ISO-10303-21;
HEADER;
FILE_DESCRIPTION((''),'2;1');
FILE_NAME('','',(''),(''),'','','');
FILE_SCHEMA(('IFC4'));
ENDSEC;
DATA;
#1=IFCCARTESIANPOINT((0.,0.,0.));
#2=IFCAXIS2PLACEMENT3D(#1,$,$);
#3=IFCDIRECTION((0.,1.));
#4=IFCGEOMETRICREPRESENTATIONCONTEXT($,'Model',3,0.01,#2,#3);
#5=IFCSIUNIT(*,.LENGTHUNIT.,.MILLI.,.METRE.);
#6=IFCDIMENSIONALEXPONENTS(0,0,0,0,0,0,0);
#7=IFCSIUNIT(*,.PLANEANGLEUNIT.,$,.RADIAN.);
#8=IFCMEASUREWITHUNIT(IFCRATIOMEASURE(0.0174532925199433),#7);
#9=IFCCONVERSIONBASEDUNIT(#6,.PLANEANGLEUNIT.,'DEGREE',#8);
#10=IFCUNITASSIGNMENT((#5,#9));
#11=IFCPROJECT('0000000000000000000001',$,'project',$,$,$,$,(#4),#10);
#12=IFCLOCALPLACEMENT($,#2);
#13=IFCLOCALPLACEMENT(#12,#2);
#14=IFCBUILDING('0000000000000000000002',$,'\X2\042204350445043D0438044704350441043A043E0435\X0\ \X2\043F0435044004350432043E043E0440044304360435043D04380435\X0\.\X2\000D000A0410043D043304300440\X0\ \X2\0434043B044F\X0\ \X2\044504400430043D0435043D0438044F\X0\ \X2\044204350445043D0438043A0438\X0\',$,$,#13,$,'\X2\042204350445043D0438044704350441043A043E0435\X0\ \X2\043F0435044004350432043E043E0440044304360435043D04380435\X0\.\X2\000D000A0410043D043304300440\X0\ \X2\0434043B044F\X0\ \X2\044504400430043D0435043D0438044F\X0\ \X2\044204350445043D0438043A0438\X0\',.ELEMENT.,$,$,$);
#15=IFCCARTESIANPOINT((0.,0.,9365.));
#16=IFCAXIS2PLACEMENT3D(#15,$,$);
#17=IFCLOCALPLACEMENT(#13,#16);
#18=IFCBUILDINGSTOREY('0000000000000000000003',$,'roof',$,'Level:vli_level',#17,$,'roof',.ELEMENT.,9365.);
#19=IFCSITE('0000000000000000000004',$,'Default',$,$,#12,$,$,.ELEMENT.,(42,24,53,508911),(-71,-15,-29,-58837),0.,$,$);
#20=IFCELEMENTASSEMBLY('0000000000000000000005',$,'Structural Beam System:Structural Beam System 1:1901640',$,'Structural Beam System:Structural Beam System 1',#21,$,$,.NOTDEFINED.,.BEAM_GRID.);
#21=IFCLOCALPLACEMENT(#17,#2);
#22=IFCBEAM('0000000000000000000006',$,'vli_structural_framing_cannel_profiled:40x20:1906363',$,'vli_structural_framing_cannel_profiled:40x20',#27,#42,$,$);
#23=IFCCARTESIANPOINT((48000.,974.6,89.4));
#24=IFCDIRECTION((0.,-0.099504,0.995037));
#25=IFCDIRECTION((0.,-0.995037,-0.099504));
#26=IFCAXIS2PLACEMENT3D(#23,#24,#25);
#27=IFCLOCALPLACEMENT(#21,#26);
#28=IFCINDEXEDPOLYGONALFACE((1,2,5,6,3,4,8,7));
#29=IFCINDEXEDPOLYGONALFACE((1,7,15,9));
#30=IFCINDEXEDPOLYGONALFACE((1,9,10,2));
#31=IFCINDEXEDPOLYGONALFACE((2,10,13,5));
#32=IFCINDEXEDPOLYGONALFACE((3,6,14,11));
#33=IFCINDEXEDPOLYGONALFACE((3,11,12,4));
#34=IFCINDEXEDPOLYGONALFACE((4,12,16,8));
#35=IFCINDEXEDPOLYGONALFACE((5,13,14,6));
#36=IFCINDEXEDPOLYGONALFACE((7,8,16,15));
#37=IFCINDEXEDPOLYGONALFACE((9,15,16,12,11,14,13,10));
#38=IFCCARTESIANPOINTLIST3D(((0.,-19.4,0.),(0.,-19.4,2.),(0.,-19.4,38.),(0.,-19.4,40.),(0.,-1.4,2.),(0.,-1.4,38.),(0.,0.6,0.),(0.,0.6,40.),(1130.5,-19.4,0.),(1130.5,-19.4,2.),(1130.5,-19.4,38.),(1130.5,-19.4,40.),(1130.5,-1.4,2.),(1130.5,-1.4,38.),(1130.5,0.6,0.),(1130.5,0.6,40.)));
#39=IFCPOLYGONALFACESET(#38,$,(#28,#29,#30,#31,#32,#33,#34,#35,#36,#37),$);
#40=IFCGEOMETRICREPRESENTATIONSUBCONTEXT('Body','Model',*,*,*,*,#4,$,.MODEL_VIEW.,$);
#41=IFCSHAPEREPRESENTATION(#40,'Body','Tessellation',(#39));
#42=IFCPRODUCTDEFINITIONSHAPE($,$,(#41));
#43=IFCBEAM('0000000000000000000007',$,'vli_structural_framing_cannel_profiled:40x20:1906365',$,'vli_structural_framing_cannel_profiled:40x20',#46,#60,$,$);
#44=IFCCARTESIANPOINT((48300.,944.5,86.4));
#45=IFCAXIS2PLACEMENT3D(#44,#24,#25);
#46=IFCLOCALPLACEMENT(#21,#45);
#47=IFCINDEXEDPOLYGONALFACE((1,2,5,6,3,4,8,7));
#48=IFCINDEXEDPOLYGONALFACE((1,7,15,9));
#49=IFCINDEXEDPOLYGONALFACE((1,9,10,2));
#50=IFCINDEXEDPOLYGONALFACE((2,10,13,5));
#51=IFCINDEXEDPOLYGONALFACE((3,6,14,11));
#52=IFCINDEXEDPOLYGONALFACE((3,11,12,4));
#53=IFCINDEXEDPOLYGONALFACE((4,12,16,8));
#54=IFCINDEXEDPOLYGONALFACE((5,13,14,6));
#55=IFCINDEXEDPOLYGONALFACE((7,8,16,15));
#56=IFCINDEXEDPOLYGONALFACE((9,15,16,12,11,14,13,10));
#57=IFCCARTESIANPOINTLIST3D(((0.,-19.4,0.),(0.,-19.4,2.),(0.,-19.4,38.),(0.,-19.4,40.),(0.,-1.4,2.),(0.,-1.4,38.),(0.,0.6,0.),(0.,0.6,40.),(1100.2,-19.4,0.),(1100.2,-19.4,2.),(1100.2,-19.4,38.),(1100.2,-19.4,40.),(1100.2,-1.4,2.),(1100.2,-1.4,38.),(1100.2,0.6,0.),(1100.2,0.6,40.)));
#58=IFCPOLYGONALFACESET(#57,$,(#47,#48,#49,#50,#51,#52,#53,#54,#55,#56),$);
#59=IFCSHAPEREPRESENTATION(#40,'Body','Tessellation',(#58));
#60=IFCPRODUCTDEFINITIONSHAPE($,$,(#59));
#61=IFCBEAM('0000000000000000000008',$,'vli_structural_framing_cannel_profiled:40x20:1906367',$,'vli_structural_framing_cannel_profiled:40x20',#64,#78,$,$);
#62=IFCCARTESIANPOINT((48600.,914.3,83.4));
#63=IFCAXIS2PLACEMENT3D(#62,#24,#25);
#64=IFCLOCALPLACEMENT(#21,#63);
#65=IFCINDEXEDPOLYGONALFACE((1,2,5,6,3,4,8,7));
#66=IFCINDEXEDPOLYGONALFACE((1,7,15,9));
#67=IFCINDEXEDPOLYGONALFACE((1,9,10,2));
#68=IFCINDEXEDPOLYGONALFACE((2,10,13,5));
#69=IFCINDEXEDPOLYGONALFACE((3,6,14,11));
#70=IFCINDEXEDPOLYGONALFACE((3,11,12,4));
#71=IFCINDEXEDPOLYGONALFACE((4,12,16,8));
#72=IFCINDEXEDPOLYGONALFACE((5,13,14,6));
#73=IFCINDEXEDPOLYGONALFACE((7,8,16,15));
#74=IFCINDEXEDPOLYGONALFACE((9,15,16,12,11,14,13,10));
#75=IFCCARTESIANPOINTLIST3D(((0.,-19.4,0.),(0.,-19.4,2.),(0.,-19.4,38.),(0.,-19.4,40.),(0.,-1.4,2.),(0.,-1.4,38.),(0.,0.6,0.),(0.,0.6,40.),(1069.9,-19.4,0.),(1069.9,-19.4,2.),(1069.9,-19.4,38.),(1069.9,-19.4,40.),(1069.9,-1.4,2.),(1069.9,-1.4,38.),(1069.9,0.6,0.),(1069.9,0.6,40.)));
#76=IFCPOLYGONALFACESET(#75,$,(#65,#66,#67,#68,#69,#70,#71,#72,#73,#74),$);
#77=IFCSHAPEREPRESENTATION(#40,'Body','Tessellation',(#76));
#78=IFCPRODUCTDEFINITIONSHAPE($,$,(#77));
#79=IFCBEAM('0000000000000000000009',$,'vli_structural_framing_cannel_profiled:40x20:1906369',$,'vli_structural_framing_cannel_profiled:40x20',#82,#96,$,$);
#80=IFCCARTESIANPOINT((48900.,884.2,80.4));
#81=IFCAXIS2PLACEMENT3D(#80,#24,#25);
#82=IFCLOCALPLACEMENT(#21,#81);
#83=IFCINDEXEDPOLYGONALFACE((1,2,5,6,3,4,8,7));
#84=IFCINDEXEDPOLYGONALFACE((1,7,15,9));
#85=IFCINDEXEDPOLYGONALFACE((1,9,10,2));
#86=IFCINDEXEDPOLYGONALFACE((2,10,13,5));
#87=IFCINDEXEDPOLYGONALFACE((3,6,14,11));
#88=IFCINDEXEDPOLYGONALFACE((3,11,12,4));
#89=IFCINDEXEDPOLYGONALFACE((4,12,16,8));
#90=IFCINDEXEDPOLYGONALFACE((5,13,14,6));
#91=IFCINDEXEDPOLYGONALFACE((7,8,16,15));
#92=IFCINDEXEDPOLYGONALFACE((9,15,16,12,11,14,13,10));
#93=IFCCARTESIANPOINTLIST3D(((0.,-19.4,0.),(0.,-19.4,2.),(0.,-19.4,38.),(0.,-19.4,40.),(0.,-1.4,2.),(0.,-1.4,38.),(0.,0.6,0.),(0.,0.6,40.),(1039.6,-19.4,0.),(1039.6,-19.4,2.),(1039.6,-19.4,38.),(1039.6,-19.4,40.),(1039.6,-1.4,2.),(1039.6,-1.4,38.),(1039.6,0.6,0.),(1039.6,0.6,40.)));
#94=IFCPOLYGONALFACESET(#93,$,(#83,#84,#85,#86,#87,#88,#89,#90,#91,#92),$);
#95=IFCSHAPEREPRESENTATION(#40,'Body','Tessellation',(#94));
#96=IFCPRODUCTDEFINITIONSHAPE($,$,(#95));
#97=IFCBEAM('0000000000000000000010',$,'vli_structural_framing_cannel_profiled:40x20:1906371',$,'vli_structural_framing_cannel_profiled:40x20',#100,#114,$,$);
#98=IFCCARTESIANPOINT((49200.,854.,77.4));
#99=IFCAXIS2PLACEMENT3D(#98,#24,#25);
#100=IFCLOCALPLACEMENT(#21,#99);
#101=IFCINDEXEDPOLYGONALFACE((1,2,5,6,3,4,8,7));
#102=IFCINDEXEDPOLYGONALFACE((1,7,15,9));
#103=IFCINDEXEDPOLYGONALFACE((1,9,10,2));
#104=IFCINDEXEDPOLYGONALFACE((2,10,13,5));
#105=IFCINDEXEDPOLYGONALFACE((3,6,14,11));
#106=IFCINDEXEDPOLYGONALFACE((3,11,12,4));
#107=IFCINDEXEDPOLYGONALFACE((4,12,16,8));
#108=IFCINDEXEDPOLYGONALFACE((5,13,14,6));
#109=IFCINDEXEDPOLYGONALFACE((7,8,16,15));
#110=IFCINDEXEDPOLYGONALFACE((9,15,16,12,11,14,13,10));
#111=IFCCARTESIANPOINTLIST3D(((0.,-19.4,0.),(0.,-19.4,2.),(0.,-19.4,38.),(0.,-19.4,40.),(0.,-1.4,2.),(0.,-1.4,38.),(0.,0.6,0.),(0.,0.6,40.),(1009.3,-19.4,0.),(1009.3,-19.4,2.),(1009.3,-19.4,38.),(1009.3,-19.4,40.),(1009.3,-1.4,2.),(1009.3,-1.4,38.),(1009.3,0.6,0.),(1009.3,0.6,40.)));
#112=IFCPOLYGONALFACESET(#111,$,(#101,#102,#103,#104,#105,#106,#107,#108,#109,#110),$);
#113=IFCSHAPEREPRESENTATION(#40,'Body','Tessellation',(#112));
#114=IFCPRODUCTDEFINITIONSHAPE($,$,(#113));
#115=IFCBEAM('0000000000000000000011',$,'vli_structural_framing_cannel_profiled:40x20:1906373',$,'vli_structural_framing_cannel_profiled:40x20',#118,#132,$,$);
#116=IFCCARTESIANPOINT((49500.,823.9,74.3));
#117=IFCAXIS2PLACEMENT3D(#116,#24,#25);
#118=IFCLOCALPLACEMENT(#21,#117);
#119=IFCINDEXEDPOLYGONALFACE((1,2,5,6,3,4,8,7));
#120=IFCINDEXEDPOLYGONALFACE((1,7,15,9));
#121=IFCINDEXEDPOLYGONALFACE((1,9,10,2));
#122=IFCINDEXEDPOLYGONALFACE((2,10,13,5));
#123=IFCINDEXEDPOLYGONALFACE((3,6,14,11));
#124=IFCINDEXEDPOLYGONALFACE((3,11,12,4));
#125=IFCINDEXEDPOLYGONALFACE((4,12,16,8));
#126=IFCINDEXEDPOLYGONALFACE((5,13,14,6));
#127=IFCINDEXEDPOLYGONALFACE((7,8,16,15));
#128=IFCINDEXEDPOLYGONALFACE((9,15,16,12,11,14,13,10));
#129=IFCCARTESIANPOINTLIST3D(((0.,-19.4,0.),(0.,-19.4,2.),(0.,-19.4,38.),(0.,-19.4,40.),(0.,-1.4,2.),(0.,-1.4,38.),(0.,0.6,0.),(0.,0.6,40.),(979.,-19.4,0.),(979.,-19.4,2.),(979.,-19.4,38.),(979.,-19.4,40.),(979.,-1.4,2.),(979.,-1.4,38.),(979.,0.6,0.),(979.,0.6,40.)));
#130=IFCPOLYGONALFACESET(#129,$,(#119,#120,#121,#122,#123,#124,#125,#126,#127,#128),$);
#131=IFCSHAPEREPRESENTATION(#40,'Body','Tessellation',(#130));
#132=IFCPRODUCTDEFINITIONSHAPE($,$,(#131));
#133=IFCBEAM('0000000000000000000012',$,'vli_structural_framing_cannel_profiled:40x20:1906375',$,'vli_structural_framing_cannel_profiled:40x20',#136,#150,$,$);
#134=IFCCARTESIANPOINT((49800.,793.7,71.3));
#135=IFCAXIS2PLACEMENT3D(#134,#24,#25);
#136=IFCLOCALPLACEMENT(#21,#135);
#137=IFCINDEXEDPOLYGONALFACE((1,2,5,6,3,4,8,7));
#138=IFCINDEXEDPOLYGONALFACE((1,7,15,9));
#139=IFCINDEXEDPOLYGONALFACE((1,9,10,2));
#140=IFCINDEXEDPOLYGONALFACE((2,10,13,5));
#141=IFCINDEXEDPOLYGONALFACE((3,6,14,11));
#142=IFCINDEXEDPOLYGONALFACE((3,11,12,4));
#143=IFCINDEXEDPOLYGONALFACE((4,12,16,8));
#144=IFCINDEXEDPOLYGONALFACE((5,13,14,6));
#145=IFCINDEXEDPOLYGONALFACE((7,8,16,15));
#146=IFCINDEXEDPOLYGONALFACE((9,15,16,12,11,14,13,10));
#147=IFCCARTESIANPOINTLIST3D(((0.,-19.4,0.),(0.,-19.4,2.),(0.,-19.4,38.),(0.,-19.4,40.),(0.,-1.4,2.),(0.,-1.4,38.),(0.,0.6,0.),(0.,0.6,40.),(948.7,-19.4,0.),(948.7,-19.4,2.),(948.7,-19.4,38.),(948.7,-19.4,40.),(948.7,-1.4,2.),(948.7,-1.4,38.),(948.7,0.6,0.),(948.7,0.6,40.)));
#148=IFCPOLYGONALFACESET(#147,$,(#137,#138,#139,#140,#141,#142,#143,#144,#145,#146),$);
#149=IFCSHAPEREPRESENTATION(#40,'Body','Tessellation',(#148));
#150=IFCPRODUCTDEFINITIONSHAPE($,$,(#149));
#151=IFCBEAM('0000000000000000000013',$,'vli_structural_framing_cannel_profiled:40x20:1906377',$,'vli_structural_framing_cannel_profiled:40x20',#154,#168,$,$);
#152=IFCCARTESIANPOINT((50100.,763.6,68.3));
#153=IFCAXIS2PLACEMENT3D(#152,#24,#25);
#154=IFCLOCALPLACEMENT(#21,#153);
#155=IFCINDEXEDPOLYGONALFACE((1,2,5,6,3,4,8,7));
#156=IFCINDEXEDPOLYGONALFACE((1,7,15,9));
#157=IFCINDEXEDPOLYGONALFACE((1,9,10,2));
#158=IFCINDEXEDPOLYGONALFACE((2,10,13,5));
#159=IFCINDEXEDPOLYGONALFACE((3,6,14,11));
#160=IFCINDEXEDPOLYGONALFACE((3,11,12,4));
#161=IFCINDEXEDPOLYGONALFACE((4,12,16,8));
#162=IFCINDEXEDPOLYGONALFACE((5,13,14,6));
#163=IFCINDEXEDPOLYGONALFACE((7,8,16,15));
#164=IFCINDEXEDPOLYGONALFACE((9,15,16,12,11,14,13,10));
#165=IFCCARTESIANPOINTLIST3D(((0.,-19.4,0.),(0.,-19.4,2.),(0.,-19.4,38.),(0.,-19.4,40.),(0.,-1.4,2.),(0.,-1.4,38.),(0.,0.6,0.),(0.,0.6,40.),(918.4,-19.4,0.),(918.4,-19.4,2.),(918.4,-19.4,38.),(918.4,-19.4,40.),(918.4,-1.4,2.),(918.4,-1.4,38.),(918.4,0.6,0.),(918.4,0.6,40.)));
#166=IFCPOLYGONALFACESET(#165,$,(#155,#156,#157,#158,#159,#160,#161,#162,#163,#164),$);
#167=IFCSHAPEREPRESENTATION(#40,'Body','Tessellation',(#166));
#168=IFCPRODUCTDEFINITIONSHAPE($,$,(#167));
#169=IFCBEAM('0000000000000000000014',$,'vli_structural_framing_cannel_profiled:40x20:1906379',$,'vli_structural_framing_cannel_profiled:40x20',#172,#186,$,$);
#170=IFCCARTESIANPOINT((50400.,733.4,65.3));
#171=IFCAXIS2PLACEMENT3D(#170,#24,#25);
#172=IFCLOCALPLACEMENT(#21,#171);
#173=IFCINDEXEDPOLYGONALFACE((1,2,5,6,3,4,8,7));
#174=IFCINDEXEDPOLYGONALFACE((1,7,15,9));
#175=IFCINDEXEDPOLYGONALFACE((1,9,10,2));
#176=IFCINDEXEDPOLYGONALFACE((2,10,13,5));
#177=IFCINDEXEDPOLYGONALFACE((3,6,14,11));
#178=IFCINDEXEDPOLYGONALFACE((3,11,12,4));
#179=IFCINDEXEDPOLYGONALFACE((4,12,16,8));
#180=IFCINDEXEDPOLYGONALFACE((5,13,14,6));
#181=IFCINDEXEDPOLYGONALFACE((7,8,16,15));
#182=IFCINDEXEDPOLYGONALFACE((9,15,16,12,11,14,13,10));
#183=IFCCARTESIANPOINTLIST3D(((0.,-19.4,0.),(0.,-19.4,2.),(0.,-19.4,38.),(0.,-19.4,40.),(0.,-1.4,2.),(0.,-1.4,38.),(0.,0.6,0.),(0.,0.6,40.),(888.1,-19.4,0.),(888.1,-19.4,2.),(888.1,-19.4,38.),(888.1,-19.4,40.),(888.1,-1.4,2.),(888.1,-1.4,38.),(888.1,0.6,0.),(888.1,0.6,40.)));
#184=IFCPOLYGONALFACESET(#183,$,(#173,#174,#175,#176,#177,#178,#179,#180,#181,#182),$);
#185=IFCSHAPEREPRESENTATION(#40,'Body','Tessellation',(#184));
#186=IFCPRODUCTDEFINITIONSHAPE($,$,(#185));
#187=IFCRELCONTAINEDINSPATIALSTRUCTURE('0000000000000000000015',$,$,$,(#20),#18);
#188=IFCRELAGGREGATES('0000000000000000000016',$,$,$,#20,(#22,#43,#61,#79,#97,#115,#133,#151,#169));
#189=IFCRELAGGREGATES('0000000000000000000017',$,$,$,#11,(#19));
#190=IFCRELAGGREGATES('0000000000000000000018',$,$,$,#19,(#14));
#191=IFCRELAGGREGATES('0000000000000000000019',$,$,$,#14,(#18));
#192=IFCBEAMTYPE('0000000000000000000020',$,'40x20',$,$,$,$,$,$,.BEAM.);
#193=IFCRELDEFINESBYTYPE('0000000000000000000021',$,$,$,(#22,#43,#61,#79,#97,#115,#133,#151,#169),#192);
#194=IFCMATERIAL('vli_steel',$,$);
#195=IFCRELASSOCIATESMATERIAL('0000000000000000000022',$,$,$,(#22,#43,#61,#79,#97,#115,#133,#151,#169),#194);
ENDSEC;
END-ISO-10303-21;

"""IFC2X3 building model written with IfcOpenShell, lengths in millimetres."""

from ifc_helpers import new_model, entity, si_unit, converted_unit, direction, frame, origin, place, context, subcontext, project, spatial, polyline, outline, extrude, material, type_object, element, aggregate, save


model = new_model("IFC2X3")

# Units and contexts
model_context = context("Model", 3, precision=0.01, world=origin(), true_north=direction((0.0, 1.0)))
body_context = subcontext(model_context, "Body", "Model", "MODEL_VIEW")
ifc_project = project(units=[si_unit("LENGTHUNIT", "METRE", prefix="MILLI"), converted_unit("PLANEANGLEUNIT", "DEGREE", entity("IfcRatioMeasure", 0.0174532925199433), si_unit("PLANEANGLEUNIT", "RADIAN"), dimensions=[0, 0, 0, 0, 0, 0, 0])], contexts=[model_context])

# Site, building, storey
site_placement = place(None, origin())
site = spatial("IfcSite", under=ifc_project, at=site_placement, Name="Default", CompositionType="ELEMENT", RefLatitude=(42, 24, 53, 508911), RefLongitude=(-71, -15, -29, -58837), RefElevation=0.0)
building_placement = place(site_placement, origin())
building = spatial("IfcBuilding", under=site, at=building_placement, Name="Техническое перевооружение.\r\nАнгар для хранения техники", LongName="Техническое перевооружение.\r\nАнгар для хранения техники", CompositionType="ELEMENT")
storey_placement = place(building_placement, frame((0.0, 0.0, 9365.0)))
storey = spatial("IfcBuildingStorey", under=building, at=storey_placement, Name="roof", ObjectType="Level:vli_level", LongName="roof", CompositionType="ELEMENT", Elevation=9365.0)

# Element assembly, beams
assembly_1_placement = place(storey_placement, origin())
assembly_1 = element("IfcElementAssembly", 1, at=assembly_1_placement, inside=storey, Name="Structural Beam System:Structural Beam System 1:1901640", ObjectType="Structural Beam System:Structural Beam System 1", AssemblyPlace="NOTDEFINED", PredefinedType="BEAM_GRID")
ifc_material = material(Name="vli_steel")
beam_type = type_object("IfcBeamType", Name="40x20", PredefinedType="BEAM")
beam_1_placement = place(assembly_1_placement, frame((48000.0, 974.6, 89.4), z_axis=(0.0, -0.099504, 0.995037), x_axis=(0.0, -0.995037, -0.099504)))
beam_1 = element("IfcBeam", 2, at=beam_1_placement, type_object=beam_type, material=ifc_material, Name="vli_structural_framing_cannel_profiled:40x20:1906363", ObjectType="vli_structural_framing_cannel_profiled:40x20", context=body_context, shape_type="SweptSolid", body=[
    extrude(outline(polyline([(-20.0, -9.5), (-18.0, -9.5), (-18.0, 8.5), (18.0, 8.5), (18.0, -9.5), (20.0, -9.5), (20.0, 10.5), (-20.0, 10.5), (-20.0, -9.5)])), frame((0.0, -9.9, 20.0), z_axis=(1.0, 0.0, 0.0), x_axis=(0.0, 0.0, -1.0)), (0.0, 0.0, 1.0), 1130.5),
])
beam_2_placement = place(assembly_1_placement, frame((48300.0, 944.5, 86.4), z_axis=(0.0, -0.099504, 0.995037), x_axis=(0.0, -0.995037, -0.099504)))
beam_2 = element("IfcBeam", 3, at=beam_2_placement, type_object=beam_type, material=ifc_material, Name="vli_structural_framing_cannel_profiled:40x20:1906365", ObjectType="vli_structural_framing_cannel_profiled:40x20", context=body_context, shape_type="SweptSolid", body=[
    extrude(outline(polyline([(-20.0, -9.5), (-18.0, -9.5), (-18.0, 8.5), (18.0, 8.5), (18.0, -9.5), (20.0, -9.5), (20.0, 10.5), (-20.0, 10.5), (-20.0, -9.5)])), frame((0.0, -9.9, 20.0), z_axis=(1.0, 0.0, 0.0), x_axis=(0.0, 0.0, -1.0)), (0.0, 0.0, 1.0), 1100.2),
])
beam_3_placement = place(assembly_1_placement, frame((48600.0, 914.3, 83.4), z_axis=(0.0, -0.099504, 0.995037), x_axis=(0.0, -0.995037, -0.099504)))
beam_3 = element("IfcBeam", 4, at=beam_3_placement, type_object=beam_type, material=ifc_material, Name="vli_structural_framing_cannel_profiled:40x20:1906367", ObjectType="vli_structural_framing_cannel_profiled:40x20", context=body_context, shape_type="SweptSolid", body=[
    extrude(outline(polyline([(-20.0, -9.5), (-18.0, -9.5), (-18.0, 8.5), (18.0, 8.5), (18.0, -9.5), (20.0, -9.5), (20.0, 10.5), (-20.0, 10.5), (-20.0, -9.5)])), frame((0.0, -9.9, 20.0), z_axis=(1.0, 0.0, 0.0), x_axis=(0.0, 0.0, -1.0)), (0.0, 0.0, 1.0), 1069.9),
])
beam_4_placement = place(assembly_1_placement, frame((48900.0, 884.2, 80.4), z_axis=(0.0, -0.099504, 0.995037), x_axis=(0.0, -0.995037, -0.099504)))
beam_4 = element("IfcBeam", 5, at=beam_4_placement, type_object=beam_type, material=ifc_material, Name="vli_structural_framing_cannel_profiled:40x20:1906369", ObjectType="vli_structural_framing_cannel_profiled:40x20", context=body_context, shape_type="SweptSolid", body=[
    extrude(outline(polyline([(-20.0, -9.5), (-18.0, -9.5), (-18.0, 8.5), (18.0, 8.5), (18.0, -9.5), (20.0, -9.5), (20.0, 10.5), (-20.0, 10.5), (-20.0, -9.5)])), frame((0.0, -9.9, 20.0), z_axis=(1.0, 0.0, 0.0), x_axis=(0.0, 0.0, -1.0)), (0.0, 0.0, 1.0), 1039.6),
])
beam_5_placement = place(assembly_1_placement, frame((49200.0, 854.0, 77.4), z_axis=(0.0, -0.099504, 0.995037), x_axis=(0.0, -0.995037, -0.099504)))
beam_5 = element("IfcBeam", 6, at=beam_5_placement, type_object=beam_type, material=ifc_material, Name="vli_structural_framing_cannel_profiled:40x20:1906371", ObjectType="vli_structural_framing_cannel_profiled:40x20", context=body_context, shape_type="SweptSolid", body=[
    extrude(outline(polyline([(-20.0, -9.5), (-18.0, -9.5), (-18.0, 8.5), (18.0, 8.5), (18.0, -9.5), (20.0, -9.5), (20.0, 10.5), (-20.0, 10.5), (-20.0, -9.5)])), frame((0.0, -9.9, 20.0), z_axis=(1.0, 0.0, 0.0), x_axis=(0.0, 0.0, -1.0)), (0.0, 0.0, 1.0), 1009.3),
])
beam_6_placement = place(assembly_1_placement, frame((49500.0, 823.9, 74.3), z_axis=(0.0, -0.099504, 0.995037), x_axis=(0.0, -0.995037, -0.099504)))
beam_6 = element("IfcBeam", 7, at=beam_6_placement, type_object=beam_type, material=ifc_material, Name="vli_structural_framing_cannel_profiled:40x20:1906373", ObjectType="vli_structural_framing_cannel_profiled:40x20", context=body_context, shape_type="SweptSolid", body=[
    extrude(outline(polyline([(-20.0, -9.5), (-18.0, -9.5), (-18.0, 8.5), (18.0, 8.5), (18.0, -9.5), (20.0, -9.5), (20.0, 10.5), (-20.0, 10.5), (-20.0, -9.5)])), frame((0.0, -9.9, 20.0), z_axis=(1.0, 0.0, 0.0), x_axis=(0.0, 0.0, -1.0)), (0.0, 0.0, 1.0), 979.0),
])
beam_7_placement = place(assembly_1_placement, frame((49800.0, 793.7, 71.3), z_axis=(0.0, -0.099504, 0.995037), x_axis=(0.0, -0.995037, -0.099504)))
beam_7 = element("IfcBeam", 8, at=beam_7_placement, type_object=beam_type, material=ifc_material, Name="vli_structural_framing_cannel_profiled:40x20:1906375", ObjectType="vli_structural_framing_cannel_profiled:40x20", context=body_context, shape_type="SweptSolid", body=[
    extrude(outline(polyline([(-20.0, -9.5), (-18.0, -9.5), (-18.0, 8.5), (18.0, 8.5), (18.0, -9.5), (20.0, -9.5), (20.0, 10.5), (-20.0, 10.5), (-20.0, -9.5)])), frame((0.0, -9.9, 20.0), z_axis=(1.0, 0.0, 0.0), x_axis=(0.0, 0.0, -1.0)), (0.0, 0.0, 1.0), 948.7),
])
beam_8_placement = place(assembly_1_placement, frame((50100.0, 763.6, 68.3), z_axis=(0.0, -0.099504, 0.995037), x_axis=(0.0, -0.995037, -0.099504)))
beam_8 = element("IfcBeam", 9, at=beam_8_placement, type_object=beam_type, material=ifc_material, Name="vli_structural_framing_cannel_profiled:40x20:1906377", ObjectType="vli_structural_framing_cannel_profiled:40x20", context=body_context, shape_type="SweptSolid", body=[
    extrude(outline(polyline([(-20.0, -9.5), (-18.0, -9.5), (-18.0, 8.5), (18.0, 8.5), (18.0, -9.5), (20.0, -9.5), (20.0, 10.5), (-20.0, 10.5), (-20.0, -9.5)])), frame((0.0, -9.9, 20.0), z_axis=(1.0, 0.0, 0.0), x_axis=(0.0, 0.0, -1.0)), (0.0, 0.0, 1.0), 918.4),
])
beam_9_placement = place(assembly_1_placement, frame((50400.0, 733.4, 65.3), z_axis=(0.0, -0.099504, 0.995037), x_axis=(0.0, -0.995037, -0.099504)))
beam_9 = element("IfcBeam", 10, at=beam_9_placement, type_object=beam_type, material=ifc_material, Name="vli_structural_framing_cannel_profiled:40x20:1906379", ObjectType="vli_structural_framing_cannel_profiled:40x20", context=body_context, shape_type="SweptSolid", body=[
    extrude(outline(polyline([(-20.0, -9.5), (-18.0, -9.5), (-18.0, 8.5), (18.0, 8.5), (18.0, -9.5), (20.0, -9.5), (20.0, 10.5), (-20.0, 10.5), (-20.0, -9.5)])), frame((0.0, -9.9, 20.0), z_axis=(1.0, 0.0, 0.0), x_axis=(0.0, 0.0, -1.0)), (0.0, 0.0, 1.0), 888.1),
])
aggregate(assembly_1, [beam_1, beam_2, beam_3, beam_4, beam_5, beam_6, beam_7, beam_8, beam_9])

save(model, "model.ifc")
